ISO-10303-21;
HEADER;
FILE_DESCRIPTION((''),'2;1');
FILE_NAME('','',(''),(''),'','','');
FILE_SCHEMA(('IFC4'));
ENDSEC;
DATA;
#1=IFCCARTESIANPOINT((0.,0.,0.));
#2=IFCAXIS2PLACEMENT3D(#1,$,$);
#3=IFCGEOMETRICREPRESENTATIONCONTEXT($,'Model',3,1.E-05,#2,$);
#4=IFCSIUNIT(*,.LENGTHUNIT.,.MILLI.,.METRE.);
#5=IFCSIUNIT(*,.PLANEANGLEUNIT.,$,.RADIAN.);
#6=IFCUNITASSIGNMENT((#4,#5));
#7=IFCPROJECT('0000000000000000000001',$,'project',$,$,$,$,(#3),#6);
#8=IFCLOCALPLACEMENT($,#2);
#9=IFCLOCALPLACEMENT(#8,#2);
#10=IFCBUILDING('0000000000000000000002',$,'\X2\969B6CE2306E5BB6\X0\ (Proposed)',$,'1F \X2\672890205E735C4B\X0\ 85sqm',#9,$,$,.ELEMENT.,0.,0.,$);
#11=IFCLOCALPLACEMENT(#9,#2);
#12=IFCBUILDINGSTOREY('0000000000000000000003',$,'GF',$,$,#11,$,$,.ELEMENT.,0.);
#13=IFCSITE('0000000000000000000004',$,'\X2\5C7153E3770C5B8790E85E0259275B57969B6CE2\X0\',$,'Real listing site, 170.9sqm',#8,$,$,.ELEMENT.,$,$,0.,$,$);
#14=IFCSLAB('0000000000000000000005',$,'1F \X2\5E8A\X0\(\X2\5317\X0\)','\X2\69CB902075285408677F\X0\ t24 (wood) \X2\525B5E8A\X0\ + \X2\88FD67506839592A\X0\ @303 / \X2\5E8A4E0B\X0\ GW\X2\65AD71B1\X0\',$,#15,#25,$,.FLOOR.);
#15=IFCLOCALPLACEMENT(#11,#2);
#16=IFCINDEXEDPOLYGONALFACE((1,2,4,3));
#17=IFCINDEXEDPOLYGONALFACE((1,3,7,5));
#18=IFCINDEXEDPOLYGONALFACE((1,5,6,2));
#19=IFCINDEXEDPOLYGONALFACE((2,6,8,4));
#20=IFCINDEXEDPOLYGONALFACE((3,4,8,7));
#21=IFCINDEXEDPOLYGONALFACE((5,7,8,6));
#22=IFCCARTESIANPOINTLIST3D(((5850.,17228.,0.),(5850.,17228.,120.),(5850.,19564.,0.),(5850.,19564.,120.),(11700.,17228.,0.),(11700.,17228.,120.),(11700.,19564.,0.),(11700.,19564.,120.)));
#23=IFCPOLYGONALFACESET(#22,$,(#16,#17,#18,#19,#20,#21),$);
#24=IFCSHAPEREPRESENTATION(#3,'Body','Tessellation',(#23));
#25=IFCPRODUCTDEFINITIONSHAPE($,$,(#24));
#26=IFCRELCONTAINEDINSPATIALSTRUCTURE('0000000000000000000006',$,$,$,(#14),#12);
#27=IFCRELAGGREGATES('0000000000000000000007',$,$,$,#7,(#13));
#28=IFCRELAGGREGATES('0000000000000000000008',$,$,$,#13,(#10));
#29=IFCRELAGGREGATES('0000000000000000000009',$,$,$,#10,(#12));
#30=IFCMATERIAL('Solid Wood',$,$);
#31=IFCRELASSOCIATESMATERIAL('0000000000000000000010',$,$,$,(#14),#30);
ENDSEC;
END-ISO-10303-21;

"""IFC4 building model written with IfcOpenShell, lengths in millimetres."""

from ifc_helpers import new_model, si_unit, frame, frame_2d, origin, place, context, project, spatial, rectangle, extrude, material, element, save


model = new_model("IFC4")

# Units and contexts
model_context = context("Model", 3, precision=1e-05, world=origin())
ifc_project = project(units=[si_unit("LENGTHUNIT", "METRE", prefix="MILLI"), si_unit("PLANEANGLEUNIT", "RADIAN")], contexts=[model_context])

# Site, building, storey
site_placement = place(None, origin())
site = spatial("IfcSite", under=ifc_project, at=site_placement, Name="山口県宇部市大字際波", ObjectType="Real listing site, 170.9sqm", CompositionType="ELEMENT", RefElevation=0.0)
building_placement = place(site_placement, origin())
building = spatial("IfcBuilding", under=site, at=building_placement, Name="際波の家 (Proposed)", ObjectType="1F 木造平屋 85sqm", CompositionType="ELEMENT", ElevationOfRefHeight=0.0, ElevationOfTerrain=0.0)
storey_placement = place(building_placement, origin())
storey = spatial("IfcBuildingStorey", under=building, at=storey_placement, Name="GF", CompositionType="ELEMENT", Elevation=0.0)

# Slab
ifc_material_1 = material(Name="Solid Wood")
slab_1_placement = place(storey_placement, frame((2925.0, 8614.0, 0.0)))
element("IfcSlab", 1, at=slab_1_placement, inside=storey, material=ifc_material_1, Name="1F 床(北)", Description="構造用合板 t24 (wood) 剛床 + 製材根太 @303 / 床下 GW断熱", PredefinedType="FLOOR", context=model_context, shape_type="SweptSolid", body=[
    extrude(rectangle(XDim=5850.0, YDim=2336.0, at=frame_2d((2925.0, 1168.0))), frame((2925.0, 8614.0, 0.0)), (0.0, 0.0, 1.0), 120.0),
])

save(model, "model.ifc")
